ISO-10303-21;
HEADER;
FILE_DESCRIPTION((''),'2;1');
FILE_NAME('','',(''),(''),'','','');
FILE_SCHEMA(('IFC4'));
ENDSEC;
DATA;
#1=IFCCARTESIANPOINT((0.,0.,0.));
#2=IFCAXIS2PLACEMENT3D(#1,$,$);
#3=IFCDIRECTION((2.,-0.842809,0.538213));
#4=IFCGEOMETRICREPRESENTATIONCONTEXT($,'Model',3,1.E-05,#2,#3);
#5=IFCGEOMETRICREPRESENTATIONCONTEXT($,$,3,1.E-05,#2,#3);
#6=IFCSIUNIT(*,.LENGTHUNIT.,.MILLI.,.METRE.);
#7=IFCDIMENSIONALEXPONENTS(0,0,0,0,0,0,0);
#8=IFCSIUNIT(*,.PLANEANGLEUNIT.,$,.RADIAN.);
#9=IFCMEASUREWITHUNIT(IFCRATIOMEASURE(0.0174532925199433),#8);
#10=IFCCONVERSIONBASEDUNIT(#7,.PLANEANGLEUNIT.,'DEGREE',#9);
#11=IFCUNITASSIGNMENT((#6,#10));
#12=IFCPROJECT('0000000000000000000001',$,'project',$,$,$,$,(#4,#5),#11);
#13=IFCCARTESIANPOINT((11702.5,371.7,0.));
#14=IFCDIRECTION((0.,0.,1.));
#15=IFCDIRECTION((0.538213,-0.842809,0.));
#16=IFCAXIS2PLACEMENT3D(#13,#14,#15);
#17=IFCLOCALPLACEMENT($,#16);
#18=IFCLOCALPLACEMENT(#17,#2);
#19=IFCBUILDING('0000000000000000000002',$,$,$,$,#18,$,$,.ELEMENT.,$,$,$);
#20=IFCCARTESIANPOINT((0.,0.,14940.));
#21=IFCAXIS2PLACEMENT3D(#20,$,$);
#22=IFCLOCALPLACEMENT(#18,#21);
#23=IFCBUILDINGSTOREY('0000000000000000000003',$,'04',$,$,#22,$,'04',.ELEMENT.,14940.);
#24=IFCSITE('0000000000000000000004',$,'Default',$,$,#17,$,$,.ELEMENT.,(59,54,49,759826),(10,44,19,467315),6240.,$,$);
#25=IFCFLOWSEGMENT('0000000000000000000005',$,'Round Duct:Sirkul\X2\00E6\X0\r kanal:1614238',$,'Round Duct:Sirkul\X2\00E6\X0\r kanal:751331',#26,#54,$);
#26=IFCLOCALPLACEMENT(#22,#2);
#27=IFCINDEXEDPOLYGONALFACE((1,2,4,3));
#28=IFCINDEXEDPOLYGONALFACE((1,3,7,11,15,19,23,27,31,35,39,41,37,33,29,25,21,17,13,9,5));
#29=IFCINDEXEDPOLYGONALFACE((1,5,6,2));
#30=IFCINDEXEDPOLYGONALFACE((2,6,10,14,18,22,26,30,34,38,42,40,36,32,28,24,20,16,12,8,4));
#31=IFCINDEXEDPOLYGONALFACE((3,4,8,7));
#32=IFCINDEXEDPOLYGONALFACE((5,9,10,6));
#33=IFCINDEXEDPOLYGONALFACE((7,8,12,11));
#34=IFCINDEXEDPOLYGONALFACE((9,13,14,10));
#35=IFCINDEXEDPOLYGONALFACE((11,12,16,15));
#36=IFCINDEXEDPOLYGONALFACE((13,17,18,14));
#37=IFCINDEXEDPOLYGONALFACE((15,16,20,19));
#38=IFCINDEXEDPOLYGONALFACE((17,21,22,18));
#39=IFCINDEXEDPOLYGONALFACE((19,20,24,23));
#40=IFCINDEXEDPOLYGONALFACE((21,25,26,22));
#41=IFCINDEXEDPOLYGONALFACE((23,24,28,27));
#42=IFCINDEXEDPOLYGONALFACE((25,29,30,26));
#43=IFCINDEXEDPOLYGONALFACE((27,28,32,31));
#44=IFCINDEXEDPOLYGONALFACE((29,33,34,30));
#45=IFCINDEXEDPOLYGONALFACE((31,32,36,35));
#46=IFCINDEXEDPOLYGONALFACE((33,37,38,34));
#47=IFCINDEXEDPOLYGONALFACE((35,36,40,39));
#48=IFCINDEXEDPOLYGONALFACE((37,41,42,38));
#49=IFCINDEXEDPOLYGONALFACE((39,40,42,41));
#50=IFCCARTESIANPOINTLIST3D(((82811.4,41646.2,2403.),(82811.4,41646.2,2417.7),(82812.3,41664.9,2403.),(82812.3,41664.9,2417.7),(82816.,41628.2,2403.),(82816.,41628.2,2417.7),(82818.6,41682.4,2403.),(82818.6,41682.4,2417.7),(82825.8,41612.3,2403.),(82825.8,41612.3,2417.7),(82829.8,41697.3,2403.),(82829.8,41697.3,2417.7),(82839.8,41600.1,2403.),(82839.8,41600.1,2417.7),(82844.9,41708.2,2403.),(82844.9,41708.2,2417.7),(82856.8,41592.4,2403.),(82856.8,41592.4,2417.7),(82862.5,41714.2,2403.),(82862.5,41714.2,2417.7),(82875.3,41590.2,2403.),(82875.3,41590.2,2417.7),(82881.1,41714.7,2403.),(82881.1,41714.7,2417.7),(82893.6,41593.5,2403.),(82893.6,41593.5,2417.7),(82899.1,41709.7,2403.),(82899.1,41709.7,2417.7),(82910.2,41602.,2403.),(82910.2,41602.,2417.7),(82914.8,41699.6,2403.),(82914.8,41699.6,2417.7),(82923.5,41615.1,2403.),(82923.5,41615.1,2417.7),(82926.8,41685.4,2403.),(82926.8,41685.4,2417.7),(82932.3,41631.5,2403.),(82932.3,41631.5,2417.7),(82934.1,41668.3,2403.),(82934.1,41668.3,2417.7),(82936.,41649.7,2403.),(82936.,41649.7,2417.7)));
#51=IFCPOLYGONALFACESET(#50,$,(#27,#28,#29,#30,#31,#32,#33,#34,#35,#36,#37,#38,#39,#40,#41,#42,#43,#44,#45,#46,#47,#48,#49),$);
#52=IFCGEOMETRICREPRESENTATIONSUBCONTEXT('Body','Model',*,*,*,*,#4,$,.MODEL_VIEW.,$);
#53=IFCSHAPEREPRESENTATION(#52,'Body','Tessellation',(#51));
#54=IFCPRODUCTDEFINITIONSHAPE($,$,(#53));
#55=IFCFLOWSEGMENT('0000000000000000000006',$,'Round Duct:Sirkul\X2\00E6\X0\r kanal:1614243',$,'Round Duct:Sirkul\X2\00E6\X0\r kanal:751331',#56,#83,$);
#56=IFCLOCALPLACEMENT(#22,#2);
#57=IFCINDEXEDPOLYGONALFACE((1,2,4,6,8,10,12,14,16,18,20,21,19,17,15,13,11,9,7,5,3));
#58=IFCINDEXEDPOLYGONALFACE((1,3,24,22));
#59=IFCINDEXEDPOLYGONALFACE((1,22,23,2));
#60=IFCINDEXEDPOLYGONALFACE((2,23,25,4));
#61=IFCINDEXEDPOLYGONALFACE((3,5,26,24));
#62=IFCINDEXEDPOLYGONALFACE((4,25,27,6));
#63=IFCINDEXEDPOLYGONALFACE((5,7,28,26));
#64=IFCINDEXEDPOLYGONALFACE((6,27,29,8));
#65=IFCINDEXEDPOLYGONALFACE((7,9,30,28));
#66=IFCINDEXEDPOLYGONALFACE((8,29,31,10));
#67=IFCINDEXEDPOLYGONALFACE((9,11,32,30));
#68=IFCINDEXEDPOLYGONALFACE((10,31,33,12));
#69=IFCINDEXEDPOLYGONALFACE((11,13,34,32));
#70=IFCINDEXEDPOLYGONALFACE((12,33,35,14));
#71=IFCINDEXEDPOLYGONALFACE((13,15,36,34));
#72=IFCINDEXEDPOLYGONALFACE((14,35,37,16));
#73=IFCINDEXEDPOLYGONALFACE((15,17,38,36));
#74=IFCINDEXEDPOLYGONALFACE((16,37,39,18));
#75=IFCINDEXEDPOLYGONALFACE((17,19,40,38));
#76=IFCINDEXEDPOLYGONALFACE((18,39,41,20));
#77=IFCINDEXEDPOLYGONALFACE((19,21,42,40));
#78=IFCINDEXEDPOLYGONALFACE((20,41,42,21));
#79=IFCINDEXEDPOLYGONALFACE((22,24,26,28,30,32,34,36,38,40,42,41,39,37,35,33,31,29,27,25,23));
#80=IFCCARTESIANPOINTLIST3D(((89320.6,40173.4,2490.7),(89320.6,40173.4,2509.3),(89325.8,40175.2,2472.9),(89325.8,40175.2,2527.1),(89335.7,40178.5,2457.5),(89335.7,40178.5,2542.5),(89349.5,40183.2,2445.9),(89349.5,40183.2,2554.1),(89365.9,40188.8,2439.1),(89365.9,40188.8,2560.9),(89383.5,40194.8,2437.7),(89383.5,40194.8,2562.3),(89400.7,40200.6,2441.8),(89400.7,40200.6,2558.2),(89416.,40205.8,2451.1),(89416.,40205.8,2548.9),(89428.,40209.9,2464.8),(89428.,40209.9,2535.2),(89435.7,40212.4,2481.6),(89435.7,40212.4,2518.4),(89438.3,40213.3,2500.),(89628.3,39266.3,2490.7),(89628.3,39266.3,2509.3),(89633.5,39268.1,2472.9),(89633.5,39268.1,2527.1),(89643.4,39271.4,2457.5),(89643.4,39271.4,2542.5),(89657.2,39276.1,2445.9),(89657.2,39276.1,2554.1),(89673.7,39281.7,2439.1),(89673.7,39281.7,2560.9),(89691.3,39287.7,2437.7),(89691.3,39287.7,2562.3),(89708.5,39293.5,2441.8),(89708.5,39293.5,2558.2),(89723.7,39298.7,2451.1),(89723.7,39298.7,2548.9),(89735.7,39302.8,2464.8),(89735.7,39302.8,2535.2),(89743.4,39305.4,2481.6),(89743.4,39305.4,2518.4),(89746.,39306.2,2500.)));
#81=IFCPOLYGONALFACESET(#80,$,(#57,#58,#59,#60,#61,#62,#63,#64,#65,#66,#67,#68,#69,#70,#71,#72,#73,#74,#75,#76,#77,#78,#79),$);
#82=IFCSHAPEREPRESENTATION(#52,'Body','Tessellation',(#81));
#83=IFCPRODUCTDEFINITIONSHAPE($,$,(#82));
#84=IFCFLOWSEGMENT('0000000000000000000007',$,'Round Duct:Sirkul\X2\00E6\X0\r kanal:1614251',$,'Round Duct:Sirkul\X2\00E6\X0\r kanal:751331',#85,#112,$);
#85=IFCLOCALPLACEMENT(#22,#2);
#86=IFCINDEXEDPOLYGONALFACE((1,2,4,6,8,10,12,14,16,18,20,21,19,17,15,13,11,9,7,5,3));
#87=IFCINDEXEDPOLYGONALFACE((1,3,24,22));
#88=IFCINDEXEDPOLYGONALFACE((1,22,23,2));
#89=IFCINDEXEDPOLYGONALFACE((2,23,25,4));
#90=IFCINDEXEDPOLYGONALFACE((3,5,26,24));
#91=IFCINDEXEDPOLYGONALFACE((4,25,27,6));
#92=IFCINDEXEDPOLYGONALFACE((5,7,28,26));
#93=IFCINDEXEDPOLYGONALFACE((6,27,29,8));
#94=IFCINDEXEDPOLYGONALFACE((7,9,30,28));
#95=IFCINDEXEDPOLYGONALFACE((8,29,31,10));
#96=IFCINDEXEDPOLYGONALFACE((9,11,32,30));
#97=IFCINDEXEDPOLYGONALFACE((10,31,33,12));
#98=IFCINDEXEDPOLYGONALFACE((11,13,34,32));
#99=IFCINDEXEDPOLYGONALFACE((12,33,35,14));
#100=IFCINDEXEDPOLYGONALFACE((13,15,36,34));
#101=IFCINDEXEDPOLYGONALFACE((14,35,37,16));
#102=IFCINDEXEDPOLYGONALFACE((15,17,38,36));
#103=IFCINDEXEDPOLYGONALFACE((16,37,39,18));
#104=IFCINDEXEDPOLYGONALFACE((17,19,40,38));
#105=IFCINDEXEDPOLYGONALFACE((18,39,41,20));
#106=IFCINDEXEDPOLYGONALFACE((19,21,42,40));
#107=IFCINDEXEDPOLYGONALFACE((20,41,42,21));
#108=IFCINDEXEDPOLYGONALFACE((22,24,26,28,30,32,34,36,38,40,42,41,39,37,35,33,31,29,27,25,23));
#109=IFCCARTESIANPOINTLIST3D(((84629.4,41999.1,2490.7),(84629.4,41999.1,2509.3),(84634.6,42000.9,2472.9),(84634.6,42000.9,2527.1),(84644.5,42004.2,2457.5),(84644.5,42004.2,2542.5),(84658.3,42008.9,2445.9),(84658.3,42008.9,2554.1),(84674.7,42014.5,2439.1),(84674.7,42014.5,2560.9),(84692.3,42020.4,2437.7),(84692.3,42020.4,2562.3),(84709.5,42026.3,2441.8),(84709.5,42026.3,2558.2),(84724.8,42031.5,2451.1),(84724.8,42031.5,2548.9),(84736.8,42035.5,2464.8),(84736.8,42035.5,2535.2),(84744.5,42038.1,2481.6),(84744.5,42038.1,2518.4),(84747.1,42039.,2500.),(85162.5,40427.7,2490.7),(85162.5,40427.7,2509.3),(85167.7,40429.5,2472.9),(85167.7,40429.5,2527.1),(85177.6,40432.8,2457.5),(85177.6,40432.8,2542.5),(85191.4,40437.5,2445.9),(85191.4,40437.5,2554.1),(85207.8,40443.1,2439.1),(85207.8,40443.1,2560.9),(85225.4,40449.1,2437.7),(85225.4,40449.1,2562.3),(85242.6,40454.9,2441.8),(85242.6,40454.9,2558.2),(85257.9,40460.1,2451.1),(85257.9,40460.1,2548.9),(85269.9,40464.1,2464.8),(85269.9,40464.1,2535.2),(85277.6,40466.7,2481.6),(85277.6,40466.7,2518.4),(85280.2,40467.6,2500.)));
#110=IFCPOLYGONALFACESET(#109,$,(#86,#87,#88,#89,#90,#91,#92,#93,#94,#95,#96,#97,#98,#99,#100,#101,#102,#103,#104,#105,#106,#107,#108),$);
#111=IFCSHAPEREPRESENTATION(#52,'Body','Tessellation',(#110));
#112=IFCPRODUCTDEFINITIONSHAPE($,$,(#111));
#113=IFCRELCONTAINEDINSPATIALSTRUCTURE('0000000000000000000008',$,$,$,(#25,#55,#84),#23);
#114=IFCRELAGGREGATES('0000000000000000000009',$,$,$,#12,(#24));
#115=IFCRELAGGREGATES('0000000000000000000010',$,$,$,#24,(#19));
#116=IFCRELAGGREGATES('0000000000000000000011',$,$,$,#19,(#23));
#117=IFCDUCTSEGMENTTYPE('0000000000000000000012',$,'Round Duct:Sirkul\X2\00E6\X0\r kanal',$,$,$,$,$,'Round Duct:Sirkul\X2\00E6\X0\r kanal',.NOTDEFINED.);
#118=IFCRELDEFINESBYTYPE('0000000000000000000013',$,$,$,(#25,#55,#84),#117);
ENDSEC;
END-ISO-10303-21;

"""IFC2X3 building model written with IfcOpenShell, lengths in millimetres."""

from ifc_helpers import new_model, entity, si_unit, converted_unit, direction, frame, frame_2d, origin, origin_2d_with_axis, place, context, subcontext, project, spatial, circle, extrude, type_object, element, save


model = new_model("IFC2X3")

# Units and contexts
model_context = context("Model", 3, precision=1e-05, world=origin(), true_north=direction((2.0, -0.842809, 0.538213)))
context_of_model = context(None, 3, precision=1e-05, world=origin(), true_north=direction((2.0, -0.842809, 0.538213)))
body_context = subcontext(model_context, "Body", "Model", "MODEL_VIEW")
ifc_project = project(units=[si_unit("LENGTHUNIT", "METRE", prefix="MILLI"), converted_unit("PLANEANGLEUNIT", "DEGREE", entity("IfcRatioMeasure", 0.0174532925199433), si_unit("PLANEANGLEUNIT", "RADIAN"), dimensions=[0, 0, 0, 0, 0, 0, 0])], contexts=[model_context, context_of_model])

# Site, building, storey
site_placement = place(None, frame((11702.5, 371.7, 0.0), z_axis=(0.0, 0.0, 1.0), x_axis=(0.538213, -0.842809, 0.0)))
site = spatial("IfcSite", under=ifc_project, at=site_placement, Name="Default", CompositionType="ELEMENT", RefLatitude=(59, 54, 49, 759826), RefLongitude=(10, 44, 19, 467315), RefElevation=6240.0)
building_placement = place(site_placement, origin())
building = spatial("IfcBuilding", under=site, at=building_placement, CompositionType="ELEMENT")
storey_placement = place(building_placement, frame((0.0, 0.0, 14940.0)))
storey = spatial("IfcBuildingStorey", under=building, at=storey_placement, Name="04", LongName="04", CompositionType="ELEMENT", Elevation=14940.0)

# Flow segments
duct_segment_type = type_object("IfcDuctSegmentType", Name="Round Duct:Sirkulær kanal", ElementType="Round Duct:Sirkulær kanal", PredefinedType="NOTDEFINED")
flow_segment_1_placement = place(storey_placement, origin())
element("IfcFlowSegment", 1, at=flow_segment_1_placement, inside=storey, type_object=duct_segment_type, Name="Round Duct:Sirkulær kanal:1614238", ObjectType="Round Duct:Sirkulær kanal:751331", context=body_context, shape_type="SweptSolid", body=[
    extrude(circle(Radius=62.5, at=frame_2d((0.0, 0.0), x_axis=(1.0, 0.0))), frame((82873.6, 41652.7, 2403.0), z_axis=(0.0, 0.0, 1.0), x_axis=(0.321274, -0.946986, 0.0)), (0.0, 0.0, 1.0), 14.7),
])
flow_segment_2_placement = place(storey_placement, origin())
element("IfcFlowSegment", 2, at=flow_segment_2_placement, inside=storey, type_object=duct_segment_type, Name="Round Duct:Sirkulær kanal:1614243", ObjectType="Round Duct:Sirkulær kanal:751331", context=body_context, shape_type="SweptSolid", body=[
    extrude(circle(Radius=62.5, at=origin_2d_with_axis()), frame((89686.8, 39286.2, 2500.0), z_axis=(-0.321274, 0.946986, 0.0), x_axis=(0.946986, 0.321274, 0.0)), (0.0, 0.0, 1.0), 957.9),
])
flow_segment_3_placement = place(storey_placement, origin())
element("IfcFlowSegment", 3, at=flow_segment_3_placement, inside=storey, type_object=duct_segment_type, Name="Round Duct:Sirkulær kanal:1614251", ObjectType="Round Duct:Sirkulær kanal:751331", context=body_context, shape_type="SweptSolid", body=[
    extrude(circle(Radius=62.5, at=frame_2d((0.0, 0.0), x_axis=(1.0, 0.0))), frame((85221.0, 40447.6, 2500.0), z_axis=(-0.321274, 0.946986, 0.0), x_axis=(0.946986, 0.321274, 0.0)), (0.0, 0.0, 1.0), 1659.4),
])

save(model, "model.ifc")
